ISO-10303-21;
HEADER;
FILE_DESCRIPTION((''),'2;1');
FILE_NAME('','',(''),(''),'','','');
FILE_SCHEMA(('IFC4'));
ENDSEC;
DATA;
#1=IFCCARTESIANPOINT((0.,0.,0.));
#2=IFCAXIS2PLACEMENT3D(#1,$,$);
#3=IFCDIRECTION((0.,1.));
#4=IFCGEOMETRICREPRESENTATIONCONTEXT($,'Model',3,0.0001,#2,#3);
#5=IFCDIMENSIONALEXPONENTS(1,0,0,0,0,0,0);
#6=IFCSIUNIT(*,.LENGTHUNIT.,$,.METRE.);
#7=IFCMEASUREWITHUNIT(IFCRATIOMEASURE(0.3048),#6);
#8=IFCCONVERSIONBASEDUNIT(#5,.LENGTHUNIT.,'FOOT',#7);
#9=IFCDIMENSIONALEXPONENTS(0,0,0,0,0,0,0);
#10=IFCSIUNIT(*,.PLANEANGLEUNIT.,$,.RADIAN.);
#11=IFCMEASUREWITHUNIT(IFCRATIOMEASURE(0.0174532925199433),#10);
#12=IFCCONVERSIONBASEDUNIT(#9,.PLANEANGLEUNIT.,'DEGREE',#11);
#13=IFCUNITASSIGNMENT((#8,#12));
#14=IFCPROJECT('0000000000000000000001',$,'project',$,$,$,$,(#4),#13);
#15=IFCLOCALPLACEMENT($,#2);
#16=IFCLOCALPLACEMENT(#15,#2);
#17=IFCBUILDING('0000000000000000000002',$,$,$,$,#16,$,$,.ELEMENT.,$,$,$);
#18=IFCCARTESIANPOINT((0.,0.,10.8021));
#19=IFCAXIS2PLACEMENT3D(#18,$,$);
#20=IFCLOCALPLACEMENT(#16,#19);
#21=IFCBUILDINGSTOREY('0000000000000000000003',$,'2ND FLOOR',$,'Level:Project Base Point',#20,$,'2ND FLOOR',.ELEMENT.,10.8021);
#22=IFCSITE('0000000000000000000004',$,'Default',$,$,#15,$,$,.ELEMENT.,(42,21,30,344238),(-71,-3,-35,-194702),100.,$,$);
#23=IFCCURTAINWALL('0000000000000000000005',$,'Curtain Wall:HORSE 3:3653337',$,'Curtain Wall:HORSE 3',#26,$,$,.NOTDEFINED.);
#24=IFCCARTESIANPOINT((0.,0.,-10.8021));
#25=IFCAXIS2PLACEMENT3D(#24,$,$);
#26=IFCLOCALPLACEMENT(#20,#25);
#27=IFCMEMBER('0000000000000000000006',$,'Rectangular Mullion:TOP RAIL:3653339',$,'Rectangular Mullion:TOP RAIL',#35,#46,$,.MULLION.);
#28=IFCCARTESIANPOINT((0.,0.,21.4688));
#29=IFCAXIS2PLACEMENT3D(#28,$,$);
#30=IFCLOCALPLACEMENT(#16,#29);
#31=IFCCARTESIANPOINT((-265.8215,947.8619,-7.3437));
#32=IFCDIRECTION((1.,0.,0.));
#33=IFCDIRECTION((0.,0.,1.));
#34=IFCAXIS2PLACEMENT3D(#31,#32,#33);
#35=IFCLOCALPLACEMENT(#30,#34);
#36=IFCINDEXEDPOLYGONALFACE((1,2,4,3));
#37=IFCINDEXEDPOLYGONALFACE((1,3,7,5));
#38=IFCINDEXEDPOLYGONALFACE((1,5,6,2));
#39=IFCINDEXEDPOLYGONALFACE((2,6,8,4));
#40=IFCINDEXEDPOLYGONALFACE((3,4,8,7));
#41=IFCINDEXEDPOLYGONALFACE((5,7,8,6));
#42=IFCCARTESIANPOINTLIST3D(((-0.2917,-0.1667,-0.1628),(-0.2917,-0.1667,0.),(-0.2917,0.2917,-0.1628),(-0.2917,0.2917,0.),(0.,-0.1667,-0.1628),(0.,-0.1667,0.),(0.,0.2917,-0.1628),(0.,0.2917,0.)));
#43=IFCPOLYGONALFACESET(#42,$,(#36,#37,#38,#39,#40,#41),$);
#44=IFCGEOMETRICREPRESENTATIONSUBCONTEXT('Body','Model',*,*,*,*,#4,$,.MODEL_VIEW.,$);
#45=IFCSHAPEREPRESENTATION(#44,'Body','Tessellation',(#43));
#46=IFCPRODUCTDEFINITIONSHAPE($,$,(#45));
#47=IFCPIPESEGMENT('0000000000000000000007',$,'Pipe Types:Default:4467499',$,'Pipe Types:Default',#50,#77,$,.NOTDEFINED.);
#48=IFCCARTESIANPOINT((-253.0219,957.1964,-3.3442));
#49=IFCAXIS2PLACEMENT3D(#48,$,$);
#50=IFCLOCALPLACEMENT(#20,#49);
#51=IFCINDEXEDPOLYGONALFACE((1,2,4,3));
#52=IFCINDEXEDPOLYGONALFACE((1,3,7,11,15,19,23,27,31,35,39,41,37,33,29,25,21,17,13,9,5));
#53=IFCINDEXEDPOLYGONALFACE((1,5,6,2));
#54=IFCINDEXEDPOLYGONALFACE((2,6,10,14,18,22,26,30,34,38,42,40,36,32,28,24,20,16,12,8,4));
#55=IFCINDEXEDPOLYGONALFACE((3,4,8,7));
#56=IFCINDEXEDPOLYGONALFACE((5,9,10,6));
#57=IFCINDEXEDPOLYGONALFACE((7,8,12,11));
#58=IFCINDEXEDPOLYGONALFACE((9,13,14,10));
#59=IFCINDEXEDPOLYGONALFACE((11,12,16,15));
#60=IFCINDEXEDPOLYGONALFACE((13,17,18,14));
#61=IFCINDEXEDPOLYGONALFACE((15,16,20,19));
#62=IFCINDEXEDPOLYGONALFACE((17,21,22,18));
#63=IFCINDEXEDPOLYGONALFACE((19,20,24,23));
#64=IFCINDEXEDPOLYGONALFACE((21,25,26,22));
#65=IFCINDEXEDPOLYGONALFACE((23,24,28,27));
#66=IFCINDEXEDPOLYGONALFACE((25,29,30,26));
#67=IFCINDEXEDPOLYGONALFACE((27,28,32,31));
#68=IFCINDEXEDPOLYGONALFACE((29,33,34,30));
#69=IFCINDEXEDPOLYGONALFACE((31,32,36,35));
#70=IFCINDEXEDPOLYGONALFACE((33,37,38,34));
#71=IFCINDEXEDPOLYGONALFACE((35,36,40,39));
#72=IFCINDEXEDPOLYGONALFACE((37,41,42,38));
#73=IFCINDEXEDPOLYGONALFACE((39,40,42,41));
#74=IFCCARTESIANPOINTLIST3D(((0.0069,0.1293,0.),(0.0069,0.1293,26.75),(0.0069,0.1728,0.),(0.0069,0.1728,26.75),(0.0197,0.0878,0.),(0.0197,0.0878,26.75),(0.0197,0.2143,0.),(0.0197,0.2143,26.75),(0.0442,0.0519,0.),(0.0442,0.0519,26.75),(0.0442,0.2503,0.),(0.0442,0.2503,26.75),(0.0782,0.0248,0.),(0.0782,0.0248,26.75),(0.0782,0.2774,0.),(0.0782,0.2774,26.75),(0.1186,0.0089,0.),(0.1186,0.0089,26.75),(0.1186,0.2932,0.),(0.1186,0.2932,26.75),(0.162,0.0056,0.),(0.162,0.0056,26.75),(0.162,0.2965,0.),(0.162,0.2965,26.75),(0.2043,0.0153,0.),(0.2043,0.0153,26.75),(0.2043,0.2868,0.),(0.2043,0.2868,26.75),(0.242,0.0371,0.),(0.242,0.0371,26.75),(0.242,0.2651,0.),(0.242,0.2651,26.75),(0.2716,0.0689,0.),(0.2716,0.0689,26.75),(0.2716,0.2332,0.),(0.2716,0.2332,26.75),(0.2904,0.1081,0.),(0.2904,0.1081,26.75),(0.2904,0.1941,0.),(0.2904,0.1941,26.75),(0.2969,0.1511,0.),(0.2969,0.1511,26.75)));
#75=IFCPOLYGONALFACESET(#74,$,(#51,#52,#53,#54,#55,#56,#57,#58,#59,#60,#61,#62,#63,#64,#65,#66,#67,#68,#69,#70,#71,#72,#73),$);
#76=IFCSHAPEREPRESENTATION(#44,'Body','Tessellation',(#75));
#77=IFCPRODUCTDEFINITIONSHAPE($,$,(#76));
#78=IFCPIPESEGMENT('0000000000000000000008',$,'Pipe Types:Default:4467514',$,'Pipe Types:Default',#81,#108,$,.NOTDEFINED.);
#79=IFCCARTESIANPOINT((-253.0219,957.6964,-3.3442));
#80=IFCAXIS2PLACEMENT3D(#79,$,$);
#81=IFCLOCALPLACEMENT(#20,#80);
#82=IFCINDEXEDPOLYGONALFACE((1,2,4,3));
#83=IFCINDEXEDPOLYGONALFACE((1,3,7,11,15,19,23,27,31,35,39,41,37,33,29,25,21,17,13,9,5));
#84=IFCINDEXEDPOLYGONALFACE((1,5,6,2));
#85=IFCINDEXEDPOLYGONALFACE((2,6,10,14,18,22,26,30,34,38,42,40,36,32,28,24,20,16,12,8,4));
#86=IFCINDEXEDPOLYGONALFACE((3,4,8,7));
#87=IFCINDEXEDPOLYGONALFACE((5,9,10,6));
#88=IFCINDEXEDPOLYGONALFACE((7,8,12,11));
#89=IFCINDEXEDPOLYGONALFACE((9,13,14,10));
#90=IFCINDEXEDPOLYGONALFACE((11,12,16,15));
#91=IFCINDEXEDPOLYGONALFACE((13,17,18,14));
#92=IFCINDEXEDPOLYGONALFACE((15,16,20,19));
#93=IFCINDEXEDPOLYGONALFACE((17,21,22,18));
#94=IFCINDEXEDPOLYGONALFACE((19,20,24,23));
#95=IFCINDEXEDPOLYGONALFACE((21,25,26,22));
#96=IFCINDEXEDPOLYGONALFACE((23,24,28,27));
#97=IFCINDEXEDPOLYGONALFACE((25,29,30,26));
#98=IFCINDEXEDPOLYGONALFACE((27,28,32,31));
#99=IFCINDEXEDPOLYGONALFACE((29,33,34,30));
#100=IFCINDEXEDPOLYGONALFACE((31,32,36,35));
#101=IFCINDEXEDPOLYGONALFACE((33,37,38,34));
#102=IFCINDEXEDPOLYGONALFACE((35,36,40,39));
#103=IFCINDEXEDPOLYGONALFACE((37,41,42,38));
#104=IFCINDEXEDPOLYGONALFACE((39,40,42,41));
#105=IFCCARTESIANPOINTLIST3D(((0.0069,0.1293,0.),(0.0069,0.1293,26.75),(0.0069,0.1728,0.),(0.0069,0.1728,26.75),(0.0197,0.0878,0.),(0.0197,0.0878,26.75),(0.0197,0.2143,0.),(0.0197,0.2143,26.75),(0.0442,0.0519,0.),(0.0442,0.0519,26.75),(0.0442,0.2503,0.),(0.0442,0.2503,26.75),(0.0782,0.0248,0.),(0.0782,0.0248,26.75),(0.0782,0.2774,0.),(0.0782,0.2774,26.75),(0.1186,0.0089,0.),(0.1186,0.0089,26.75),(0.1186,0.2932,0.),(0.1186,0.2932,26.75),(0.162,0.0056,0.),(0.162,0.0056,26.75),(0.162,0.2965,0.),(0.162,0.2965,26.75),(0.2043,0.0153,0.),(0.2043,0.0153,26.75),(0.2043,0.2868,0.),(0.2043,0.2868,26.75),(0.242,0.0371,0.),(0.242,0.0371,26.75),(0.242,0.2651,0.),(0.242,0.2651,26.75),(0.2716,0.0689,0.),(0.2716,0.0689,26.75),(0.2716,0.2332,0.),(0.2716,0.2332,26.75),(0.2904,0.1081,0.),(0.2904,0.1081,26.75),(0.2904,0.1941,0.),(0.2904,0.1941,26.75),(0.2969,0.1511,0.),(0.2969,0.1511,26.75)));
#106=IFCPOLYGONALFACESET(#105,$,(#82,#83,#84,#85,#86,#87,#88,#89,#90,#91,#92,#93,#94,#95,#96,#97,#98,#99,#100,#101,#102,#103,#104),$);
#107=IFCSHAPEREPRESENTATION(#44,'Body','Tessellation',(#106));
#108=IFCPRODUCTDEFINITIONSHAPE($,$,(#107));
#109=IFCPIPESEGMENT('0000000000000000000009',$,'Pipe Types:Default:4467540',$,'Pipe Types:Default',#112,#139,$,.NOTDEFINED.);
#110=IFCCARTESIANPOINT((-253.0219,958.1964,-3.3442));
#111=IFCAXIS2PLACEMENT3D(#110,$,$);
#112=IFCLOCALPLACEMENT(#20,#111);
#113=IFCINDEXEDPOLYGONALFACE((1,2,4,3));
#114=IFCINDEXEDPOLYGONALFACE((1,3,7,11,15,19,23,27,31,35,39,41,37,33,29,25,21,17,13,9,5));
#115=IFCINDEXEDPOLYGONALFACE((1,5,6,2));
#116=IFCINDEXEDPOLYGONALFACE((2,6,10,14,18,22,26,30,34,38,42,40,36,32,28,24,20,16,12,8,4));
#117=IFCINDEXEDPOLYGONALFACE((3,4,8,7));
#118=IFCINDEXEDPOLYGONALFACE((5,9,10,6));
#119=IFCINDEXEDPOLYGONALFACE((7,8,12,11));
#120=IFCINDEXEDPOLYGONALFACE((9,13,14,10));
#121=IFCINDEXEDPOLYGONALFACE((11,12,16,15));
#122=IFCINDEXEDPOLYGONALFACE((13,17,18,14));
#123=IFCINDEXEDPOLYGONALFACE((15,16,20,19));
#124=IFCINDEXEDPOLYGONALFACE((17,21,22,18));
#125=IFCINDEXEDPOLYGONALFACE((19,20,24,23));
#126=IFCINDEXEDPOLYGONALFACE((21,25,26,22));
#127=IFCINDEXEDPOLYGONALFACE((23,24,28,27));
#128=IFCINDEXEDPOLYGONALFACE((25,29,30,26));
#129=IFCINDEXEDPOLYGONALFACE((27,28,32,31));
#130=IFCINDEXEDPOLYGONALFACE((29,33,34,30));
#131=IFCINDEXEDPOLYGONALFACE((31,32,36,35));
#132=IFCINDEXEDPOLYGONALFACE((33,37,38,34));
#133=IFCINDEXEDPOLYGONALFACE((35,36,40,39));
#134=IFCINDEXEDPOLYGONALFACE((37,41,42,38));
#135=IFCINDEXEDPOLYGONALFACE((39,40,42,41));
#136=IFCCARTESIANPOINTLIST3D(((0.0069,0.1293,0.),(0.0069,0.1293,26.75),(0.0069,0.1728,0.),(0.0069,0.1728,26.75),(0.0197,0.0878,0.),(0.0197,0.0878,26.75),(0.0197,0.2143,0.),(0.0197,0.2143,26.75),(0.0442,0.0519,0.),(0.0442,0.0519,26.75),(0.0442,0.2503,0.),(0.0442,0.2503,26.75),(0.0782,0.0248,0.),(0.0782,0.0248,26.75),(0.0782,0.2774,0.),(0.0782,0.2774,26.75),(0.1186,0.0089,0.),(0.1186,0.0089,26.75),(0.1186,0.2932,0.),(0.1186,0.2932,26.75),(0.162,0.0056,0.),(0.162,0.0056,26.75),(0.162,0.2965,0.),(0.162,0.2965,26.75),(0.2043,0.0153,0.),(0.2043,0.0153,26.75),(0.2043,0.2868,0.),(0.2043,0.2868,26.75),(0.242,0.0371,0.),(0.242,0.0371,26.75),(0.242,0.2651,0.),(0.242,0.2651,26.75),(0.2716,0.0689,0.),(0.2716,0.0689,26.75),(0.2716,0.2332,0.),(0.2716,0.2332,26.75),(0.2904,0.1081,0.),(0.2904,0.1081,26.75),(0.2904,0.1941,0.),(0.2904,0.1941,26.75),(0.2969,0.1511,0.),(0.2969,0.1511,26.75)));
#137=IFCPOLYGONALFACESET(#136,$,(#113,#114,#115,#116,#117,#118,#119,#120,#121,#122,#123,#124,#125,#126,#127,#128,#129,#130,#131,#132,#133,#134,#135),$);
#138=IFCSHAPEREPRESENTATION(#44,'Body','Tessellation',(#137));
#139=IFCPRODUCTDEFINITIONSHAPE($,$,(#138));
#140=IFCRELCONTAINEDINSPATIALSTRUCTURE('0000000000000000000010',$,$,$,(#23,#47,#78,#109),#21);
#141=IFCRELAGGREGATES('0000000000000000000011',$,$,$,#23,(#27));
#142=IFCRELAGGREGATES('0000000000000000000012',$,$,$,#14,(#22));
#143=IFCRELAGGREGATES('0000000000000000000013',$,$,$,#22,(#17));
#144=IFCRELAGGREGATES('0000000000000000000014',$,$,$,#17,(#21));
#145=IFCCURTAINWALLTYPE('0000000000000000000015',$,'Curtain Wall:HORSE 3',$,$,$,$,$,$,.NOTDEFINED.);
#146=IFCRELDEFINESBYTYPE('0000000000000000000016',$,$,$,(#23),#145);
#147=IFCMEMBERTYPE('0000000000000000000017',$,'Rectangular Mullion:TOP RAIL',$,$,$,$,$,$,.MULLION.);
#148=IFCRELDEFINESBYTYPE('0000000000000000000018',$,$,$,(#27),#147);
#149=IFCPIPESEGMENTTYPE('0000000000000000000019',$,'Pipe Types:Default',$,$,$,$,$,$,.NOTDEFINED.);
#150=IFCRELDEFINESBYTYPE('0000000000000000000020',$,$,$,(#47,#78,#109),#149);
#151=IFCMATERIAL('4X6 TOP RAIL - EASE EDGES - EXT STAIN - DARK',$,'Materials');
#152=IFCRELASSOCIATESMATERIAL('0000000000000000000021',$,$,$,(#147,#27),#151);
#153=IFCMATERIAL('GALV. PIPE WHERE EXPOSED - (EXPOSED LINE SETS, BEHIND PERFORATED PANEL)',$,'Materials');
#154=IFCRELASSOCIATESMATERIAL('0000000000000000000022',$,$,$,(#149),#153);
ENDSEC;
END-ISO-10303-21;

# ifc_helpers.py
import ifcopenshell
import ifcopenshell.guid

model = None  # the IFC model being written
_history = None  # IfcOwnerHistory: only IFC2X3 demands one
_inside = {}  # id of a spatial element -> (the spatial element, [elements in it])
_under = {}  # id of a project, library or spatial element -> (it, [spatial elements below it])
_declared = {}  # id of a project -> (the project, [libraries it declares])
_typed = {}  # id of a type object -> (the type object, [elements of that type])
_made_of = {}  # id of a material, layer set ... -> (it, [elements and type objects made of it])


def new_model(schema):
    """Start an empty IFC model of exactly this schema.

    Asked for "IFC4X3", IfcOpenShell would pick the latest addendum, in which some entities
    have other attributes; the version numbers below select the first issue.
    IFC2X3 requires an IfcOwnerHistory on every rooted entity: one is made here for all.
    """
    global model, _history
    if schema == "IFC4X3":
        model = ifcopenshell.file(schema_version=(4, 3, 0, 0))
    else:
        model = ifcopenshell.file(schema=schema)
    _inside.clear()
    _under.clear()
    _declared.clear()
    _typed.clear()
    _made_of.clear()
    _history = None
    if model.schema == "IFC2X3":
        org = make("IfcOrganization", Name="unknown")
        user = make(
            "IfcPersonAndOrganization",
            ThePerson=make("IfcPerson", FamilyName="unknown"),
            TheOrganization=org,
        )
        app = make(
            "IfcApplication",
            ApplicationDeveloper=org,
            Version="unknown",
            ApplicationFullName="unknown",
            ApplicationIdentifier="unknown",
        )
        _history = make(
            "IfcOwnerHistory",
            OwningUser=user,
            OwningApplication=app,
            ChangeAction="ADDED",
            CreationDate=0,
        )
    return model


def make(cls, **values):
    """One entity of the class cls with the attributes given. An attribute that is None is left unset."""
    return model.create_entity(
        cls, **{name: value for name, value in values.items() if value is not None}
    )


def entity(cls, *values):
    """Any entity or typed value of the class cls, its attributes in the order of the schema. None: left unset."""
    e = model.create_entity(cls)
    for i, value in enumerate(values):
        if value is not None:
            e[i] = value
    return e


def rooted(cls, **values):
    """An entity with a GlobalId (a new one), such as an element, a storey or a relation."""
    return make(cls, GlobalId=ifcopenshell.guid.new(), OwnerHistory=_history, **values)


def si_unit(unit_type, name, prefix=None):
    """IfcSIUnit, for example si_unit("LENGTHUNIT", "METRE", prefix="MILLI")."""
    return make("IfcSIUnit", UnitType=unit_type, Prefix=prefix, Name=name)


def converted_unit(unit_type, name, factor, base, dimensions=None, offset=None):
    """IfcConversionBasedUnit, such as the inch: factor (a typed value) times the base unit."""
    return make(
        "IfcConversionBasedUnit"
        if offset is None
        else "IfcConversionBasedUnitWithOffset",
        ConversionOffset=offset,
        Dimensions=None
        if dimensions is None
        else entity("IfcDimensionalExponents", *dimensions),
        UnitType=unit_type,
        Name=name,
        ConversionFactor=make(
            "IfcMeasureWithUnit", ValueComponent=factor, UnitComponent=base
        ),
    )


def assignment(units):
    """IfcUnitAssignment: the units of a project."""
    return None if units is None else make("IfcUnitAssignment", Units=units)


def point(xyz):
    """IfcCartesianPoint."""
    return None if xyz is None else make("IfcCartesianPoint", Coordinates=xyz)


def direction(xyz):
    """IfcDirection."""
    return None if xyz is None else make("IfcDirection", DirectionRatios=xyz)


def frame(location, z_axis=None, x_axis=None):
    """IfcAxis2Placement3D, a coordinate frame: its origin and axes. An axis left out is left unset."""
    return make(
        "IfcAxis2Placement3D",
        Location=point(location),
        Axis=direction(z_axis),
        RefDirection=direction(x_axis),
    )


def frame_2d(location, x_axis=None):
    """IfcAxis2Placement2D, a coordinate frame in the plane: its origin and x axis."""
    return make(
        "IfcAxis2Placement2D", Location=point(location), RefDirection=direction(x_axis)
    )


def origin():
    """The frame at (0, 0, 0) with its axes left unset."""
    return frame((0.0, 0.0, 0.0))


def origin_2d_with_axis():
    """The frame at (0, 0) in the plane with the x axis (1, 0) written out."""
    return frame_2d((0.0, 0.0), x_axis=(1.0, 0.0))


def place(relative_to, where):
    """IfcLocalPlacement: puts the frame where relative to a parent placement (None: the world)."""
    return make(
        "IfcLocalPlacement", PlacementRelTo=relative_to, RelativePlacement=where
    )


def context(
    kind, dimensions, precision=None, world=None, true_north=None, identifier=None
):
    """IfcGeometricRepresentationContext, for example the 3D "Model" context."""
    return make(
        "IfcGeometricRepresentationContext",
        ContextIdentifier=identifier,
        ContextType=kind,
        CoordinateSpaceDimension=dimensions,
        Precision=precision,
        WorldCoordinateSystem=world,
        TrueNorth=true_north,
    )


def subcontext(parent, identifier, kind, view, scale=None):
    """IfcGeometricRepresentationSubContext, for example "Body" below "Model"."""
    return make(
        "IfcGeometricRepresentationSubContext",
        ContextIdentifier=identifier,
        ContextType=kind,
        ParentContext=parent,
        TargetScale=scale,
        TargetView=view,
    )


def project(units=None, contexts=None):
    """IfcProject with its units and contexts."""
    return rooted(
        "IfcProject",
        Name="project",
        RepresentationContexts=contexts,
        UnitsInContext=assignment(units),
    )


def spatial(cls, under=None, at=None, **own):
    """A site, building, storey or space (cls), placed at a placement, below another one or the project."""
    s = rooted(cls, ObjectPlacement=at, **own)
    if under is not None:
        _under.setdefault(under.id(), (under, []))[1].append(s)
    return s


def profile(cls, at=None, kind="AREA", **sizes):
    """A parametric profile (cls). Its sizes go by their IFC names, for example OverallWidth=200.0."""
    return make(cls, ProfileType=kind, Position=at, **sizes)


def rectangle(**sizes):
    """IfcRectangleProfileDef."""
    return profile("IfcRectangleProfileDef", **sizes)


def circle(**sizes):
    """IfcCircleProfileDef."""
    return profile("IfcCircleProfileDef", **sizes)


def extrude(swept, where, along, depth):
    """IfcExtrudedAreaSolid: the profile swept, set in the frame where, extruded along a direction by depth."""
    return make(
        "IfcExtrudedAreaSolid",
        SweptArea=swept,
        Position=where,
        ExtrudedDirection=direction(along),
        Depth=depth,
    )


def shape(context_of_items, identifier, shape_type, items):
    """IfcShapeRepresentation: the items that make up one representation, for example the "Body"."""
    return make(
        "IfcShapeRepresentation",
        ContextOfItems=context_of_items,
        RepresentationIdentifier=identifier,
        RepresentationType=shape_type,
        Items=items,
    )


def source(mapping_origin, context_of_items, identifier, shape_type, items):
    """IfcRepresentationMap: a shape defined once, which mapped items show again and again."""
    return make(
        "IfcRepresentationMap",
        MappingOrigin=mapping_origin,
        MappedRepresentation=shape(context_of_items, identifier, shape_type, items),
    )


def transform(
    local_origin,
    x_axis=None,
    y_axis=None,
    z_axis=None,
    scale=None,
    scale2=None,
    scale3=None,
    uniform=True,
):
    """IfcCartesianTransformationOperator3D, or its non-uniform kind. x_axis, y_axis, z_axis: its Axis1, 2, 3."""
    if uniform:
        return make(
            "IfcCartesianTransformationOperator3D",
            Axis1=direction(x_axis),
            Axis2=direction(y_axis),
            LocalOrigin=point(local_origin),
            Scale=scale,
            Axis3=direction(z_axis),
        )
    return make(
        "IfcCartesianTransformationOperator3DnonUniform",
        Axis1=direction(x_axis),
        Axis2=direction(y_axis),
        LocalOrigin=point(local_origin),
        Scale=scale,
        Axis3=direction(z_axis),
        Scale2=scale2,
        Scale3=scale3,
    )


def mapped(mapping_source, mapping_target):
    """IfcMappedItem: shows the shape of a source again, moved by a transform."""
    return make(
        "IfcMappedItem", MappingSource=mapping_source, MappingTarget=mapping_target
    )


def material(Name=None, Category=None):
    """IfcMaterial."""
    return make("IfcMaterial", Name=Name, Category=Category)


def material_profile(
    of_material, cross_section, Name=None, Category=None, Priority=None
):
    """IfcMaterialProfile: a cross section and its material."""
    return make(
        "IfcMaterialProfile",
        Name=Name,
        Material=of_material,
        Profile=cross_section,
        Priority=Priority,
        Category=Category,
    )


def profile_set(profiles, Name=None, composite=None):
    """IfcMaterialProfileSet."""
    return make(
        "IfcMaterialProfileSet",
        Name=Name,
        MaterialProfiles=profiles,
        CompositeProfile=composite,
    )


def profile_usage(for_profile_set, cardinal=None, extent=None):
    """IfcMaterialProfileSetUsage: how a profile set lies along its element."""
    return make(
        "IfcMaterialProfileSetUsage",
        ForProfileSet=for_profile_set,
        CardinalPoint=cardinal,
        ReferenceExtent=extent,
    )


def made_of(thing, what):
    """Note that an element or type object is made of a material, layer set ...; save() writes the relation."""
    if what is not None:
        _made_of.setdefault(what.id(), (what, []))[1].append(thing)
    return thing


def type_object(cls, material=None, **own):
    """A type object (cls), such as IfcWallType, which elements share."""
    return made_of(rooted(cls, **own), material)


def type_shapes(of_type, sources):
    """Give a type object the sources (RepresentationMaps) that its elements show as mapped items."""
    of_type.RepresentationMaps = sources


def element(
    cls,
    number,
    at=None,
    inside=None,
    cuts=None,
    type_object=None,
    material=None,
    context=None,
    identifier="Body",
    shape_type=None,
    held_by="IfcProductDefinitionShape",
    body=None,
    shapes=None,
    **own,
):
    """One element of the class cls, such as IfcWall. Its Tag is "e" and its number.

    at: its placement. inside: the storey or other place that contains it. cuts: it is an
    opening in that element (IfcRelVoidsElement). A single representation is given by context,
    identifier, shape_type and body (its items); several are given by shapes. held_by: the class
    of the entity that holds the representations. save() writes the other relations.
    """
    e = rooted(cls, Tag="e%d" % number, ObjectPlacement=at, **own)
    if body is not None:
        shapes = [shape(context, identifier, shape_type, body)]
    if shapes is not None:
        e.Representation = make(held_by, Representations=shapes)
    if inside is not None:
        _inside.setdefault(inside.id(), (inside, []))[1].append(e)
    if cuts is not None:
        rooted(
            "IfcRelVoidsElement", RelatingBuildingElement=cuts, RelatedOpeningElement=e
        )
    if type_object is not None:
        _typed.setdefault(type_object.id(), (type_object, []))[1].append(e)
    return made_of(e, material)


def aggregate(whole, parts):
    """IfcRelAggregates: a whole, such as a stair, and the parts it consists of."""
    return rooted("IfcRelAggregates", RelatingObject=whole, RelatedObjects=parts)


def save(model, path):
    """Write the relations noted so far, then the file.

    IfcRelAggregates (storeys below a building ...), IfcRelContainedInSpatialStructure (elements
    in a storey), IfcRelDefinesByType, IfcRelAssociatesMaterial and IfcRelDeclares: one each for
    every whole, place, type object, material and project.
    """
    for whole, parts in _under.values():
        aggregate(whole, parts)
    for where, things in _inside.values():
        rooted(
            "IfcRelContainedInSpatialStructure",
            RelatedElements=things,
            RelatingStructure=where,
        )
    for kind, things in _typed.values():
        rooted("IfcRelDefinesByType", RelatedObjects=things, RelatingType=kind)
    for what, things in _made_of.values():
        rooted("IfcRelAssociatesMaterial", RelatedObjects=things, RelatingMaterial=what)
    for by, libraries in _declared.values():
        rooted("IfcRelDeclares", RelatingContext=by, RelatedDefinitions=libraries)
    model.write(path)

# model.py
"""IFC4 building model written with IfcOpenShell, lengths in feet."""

from ifc_helpers import new_model, entity, si_unit, converted_unit, direction, frame, origin, origin_2d_with_axis, place, context, subcontext, project, spatial, rectangle, circle, extrude, source, transform, mapped, material, material_profile, profile_set, profile_usage, type_object, type_shapes, element, aggregate, save


model = new_model("IFC4")

# Units and contexts
model_context = context("Model", 3, precision=0.0001, world=origin(), true_north=direction((0.0, 1.0)))
body_context = subcontext(model_context, "Body", "Model", "MODEL_VIEW")
ifc_project = project(units=[converted_unit("LENGTHUNIT", "FOOT", entity("IfcRatioMeasure", 0.3048), si_unit("LENGTHUNIT", "METRE"), dimensions=[1, 0, 0, 0, 0, 0, 0]), converted_unit("PLANEANGLEUNIT", "DEGREE", entity("IfcRatioMeasure", 0.0174532925199433), si_unit("PLANEANGLEUNIT", "RADIAN"), dimensions=[0, 0, 0, 0, 0, 0, 0])], contexts=[model_context])

# Site, building, storey
site_placement = place(None, origin())
site = spatial("IfcSite", under=ifc_project, at=site_placement, Name="Default", CompositionType="ELEMENT", RefLatitude=(42, 21, 30, 344238), RefLongitude=(-71, -3, -35, -194702), RefElevation=100.0)
building_placement = place(site_placement, origin())
building = spatial("IfcBuilding", under=site, at=building_placement, CompositionType="ELEMENT")
storey_placement = place(building_placement, frame((0.0, 0.0, 10.8021)))
storey = spatial("IfcBuildingStorey", under=building, at=storey_placement, Name="2ND FLOOR", ObjectType="Level:Project Base Point", LongName="2ND FLOOR", CompositionType="ELEMENT", Elevation=10.8021)

# Curtain wall, member
curtain_wall_type = type_object("IfcCurtainWallType", Name="Curtain Wall:HORSE 3", PredefinedType="NOTDEFINED")
curtain_wall_placement = place(storey_placement, frame((0.0, 0.0, -10.8021)))
curtain_wall = element("IfcCurtainWall", 1, at=curtain_wall_placement, inside=storey, type_object=curtain_wall_type, Name="Curtain Wall:HORSE 3:3653337", ObjectType="Curtain Wall:HORSE 3", PredefinedType="NOTDEFINED")
ifc_material_1 = material(Name="4X6 TOP RAIL - EASE EDGES - EXT STAIN - DARK", Category="Materials")
ifc_material_profile_1 = material_profile(ifc_material_1, rectangle(XDim=0.4583, YDim=0.2917, at=origin_2d_with_axis()), Name="TOP RAIL")
ifc_profile_set_1 = profile_set([ifc_material_profile_1], Name="TOP RAIL")
ifc_profile_usage_1 = profile_usage(ifc_profile_set_1)
member_type_1 = type_object("IfcMemberType", Name="Rectangular Mullion:TOP RAIL", PredefinedType="MULLION", material=ifc_profile_set_1)
shared_shape_1 = source(origin(), body_context, "Body", "SweptSolid", [
    extrude(rectangle(XDim=0.4583, YDim=0.2917, at=origin_2d_with_axis()), frame((-0.1458, 0.0625, -0.1628), z_axis=(0.0, 0.0, 1.0), x_axis=(0.0, -1.0, 0.0)), (0.0, 0.0, 1.0), 0.1628),
])
type_shapes(member_type_1, [shared_shape_1])
placement = place(building_placement, frame((0.0, 0.0, 21.4688)))
member_1_placement = place(placement, frame((-265.8215, 947.8619, -7.3437), z_axis=(1.0, 0.0, 0.0), x_axis=(0.0, 0.0, 1.0)))
member_1 = element("IfcMember", 2, at=member_1_placement, type_object=member_type_1, material=ifc_profile_usage_1, Name="Rectangular Mullion:TOP RAIL:3653339", ObjectType="Rectangular Mullion:TOP RAIL", PredefinedType="MULLION", context=body_context, shape_type="MappedRepresentation", body=[
    mapped(shared_shape_1, transform((0.0, 0.0, 0.0), scale=1.0)),
])
aggregate(curtain_wall, [member_1])

# Pipe segments
ifc_material_2 = material(Name="GALV. PIPE WHERE EXPOSED - (EXPOSED LINE SETS, BEHIND PERFORATED PANEL)", Category="Materials")
pipe_segment_type = type_object("IfcPipeSegmentType", Name="Pipe Types:Default", PredefinedType="NOTDEFINED", material=ifc_material_2)
for number, where, name in (
    (3, (-253.0219, 957.1964, -3.3442), "Pipe Types:Default:4467499"),
    (4, (-253.0219, 957.6964, -3.3442), "Pipe Types:Default:4467514"),
    (5, (-253.0219, 958.1964, -3.3442), "Pipe Types:Default:4467540"),
):
    element("IfcPipeSegment", number, at=place(storey_placement, frame(where)), inside=storey, type_object=pipe_segment_type, Name=name, ObjectType="Pipe Types:Default", PredefinedType="NOTDEFINED", context=body_context, shape_type="SweptSolid", body=[
        extrude(circle(Radius=0.1458, at=origin_2d_with_axis()), frame((0.1511, 0.1511, 0.0)), (0.0, 0.0, 1.0), 26.75),
    ])

save(model, "model.ifc")
